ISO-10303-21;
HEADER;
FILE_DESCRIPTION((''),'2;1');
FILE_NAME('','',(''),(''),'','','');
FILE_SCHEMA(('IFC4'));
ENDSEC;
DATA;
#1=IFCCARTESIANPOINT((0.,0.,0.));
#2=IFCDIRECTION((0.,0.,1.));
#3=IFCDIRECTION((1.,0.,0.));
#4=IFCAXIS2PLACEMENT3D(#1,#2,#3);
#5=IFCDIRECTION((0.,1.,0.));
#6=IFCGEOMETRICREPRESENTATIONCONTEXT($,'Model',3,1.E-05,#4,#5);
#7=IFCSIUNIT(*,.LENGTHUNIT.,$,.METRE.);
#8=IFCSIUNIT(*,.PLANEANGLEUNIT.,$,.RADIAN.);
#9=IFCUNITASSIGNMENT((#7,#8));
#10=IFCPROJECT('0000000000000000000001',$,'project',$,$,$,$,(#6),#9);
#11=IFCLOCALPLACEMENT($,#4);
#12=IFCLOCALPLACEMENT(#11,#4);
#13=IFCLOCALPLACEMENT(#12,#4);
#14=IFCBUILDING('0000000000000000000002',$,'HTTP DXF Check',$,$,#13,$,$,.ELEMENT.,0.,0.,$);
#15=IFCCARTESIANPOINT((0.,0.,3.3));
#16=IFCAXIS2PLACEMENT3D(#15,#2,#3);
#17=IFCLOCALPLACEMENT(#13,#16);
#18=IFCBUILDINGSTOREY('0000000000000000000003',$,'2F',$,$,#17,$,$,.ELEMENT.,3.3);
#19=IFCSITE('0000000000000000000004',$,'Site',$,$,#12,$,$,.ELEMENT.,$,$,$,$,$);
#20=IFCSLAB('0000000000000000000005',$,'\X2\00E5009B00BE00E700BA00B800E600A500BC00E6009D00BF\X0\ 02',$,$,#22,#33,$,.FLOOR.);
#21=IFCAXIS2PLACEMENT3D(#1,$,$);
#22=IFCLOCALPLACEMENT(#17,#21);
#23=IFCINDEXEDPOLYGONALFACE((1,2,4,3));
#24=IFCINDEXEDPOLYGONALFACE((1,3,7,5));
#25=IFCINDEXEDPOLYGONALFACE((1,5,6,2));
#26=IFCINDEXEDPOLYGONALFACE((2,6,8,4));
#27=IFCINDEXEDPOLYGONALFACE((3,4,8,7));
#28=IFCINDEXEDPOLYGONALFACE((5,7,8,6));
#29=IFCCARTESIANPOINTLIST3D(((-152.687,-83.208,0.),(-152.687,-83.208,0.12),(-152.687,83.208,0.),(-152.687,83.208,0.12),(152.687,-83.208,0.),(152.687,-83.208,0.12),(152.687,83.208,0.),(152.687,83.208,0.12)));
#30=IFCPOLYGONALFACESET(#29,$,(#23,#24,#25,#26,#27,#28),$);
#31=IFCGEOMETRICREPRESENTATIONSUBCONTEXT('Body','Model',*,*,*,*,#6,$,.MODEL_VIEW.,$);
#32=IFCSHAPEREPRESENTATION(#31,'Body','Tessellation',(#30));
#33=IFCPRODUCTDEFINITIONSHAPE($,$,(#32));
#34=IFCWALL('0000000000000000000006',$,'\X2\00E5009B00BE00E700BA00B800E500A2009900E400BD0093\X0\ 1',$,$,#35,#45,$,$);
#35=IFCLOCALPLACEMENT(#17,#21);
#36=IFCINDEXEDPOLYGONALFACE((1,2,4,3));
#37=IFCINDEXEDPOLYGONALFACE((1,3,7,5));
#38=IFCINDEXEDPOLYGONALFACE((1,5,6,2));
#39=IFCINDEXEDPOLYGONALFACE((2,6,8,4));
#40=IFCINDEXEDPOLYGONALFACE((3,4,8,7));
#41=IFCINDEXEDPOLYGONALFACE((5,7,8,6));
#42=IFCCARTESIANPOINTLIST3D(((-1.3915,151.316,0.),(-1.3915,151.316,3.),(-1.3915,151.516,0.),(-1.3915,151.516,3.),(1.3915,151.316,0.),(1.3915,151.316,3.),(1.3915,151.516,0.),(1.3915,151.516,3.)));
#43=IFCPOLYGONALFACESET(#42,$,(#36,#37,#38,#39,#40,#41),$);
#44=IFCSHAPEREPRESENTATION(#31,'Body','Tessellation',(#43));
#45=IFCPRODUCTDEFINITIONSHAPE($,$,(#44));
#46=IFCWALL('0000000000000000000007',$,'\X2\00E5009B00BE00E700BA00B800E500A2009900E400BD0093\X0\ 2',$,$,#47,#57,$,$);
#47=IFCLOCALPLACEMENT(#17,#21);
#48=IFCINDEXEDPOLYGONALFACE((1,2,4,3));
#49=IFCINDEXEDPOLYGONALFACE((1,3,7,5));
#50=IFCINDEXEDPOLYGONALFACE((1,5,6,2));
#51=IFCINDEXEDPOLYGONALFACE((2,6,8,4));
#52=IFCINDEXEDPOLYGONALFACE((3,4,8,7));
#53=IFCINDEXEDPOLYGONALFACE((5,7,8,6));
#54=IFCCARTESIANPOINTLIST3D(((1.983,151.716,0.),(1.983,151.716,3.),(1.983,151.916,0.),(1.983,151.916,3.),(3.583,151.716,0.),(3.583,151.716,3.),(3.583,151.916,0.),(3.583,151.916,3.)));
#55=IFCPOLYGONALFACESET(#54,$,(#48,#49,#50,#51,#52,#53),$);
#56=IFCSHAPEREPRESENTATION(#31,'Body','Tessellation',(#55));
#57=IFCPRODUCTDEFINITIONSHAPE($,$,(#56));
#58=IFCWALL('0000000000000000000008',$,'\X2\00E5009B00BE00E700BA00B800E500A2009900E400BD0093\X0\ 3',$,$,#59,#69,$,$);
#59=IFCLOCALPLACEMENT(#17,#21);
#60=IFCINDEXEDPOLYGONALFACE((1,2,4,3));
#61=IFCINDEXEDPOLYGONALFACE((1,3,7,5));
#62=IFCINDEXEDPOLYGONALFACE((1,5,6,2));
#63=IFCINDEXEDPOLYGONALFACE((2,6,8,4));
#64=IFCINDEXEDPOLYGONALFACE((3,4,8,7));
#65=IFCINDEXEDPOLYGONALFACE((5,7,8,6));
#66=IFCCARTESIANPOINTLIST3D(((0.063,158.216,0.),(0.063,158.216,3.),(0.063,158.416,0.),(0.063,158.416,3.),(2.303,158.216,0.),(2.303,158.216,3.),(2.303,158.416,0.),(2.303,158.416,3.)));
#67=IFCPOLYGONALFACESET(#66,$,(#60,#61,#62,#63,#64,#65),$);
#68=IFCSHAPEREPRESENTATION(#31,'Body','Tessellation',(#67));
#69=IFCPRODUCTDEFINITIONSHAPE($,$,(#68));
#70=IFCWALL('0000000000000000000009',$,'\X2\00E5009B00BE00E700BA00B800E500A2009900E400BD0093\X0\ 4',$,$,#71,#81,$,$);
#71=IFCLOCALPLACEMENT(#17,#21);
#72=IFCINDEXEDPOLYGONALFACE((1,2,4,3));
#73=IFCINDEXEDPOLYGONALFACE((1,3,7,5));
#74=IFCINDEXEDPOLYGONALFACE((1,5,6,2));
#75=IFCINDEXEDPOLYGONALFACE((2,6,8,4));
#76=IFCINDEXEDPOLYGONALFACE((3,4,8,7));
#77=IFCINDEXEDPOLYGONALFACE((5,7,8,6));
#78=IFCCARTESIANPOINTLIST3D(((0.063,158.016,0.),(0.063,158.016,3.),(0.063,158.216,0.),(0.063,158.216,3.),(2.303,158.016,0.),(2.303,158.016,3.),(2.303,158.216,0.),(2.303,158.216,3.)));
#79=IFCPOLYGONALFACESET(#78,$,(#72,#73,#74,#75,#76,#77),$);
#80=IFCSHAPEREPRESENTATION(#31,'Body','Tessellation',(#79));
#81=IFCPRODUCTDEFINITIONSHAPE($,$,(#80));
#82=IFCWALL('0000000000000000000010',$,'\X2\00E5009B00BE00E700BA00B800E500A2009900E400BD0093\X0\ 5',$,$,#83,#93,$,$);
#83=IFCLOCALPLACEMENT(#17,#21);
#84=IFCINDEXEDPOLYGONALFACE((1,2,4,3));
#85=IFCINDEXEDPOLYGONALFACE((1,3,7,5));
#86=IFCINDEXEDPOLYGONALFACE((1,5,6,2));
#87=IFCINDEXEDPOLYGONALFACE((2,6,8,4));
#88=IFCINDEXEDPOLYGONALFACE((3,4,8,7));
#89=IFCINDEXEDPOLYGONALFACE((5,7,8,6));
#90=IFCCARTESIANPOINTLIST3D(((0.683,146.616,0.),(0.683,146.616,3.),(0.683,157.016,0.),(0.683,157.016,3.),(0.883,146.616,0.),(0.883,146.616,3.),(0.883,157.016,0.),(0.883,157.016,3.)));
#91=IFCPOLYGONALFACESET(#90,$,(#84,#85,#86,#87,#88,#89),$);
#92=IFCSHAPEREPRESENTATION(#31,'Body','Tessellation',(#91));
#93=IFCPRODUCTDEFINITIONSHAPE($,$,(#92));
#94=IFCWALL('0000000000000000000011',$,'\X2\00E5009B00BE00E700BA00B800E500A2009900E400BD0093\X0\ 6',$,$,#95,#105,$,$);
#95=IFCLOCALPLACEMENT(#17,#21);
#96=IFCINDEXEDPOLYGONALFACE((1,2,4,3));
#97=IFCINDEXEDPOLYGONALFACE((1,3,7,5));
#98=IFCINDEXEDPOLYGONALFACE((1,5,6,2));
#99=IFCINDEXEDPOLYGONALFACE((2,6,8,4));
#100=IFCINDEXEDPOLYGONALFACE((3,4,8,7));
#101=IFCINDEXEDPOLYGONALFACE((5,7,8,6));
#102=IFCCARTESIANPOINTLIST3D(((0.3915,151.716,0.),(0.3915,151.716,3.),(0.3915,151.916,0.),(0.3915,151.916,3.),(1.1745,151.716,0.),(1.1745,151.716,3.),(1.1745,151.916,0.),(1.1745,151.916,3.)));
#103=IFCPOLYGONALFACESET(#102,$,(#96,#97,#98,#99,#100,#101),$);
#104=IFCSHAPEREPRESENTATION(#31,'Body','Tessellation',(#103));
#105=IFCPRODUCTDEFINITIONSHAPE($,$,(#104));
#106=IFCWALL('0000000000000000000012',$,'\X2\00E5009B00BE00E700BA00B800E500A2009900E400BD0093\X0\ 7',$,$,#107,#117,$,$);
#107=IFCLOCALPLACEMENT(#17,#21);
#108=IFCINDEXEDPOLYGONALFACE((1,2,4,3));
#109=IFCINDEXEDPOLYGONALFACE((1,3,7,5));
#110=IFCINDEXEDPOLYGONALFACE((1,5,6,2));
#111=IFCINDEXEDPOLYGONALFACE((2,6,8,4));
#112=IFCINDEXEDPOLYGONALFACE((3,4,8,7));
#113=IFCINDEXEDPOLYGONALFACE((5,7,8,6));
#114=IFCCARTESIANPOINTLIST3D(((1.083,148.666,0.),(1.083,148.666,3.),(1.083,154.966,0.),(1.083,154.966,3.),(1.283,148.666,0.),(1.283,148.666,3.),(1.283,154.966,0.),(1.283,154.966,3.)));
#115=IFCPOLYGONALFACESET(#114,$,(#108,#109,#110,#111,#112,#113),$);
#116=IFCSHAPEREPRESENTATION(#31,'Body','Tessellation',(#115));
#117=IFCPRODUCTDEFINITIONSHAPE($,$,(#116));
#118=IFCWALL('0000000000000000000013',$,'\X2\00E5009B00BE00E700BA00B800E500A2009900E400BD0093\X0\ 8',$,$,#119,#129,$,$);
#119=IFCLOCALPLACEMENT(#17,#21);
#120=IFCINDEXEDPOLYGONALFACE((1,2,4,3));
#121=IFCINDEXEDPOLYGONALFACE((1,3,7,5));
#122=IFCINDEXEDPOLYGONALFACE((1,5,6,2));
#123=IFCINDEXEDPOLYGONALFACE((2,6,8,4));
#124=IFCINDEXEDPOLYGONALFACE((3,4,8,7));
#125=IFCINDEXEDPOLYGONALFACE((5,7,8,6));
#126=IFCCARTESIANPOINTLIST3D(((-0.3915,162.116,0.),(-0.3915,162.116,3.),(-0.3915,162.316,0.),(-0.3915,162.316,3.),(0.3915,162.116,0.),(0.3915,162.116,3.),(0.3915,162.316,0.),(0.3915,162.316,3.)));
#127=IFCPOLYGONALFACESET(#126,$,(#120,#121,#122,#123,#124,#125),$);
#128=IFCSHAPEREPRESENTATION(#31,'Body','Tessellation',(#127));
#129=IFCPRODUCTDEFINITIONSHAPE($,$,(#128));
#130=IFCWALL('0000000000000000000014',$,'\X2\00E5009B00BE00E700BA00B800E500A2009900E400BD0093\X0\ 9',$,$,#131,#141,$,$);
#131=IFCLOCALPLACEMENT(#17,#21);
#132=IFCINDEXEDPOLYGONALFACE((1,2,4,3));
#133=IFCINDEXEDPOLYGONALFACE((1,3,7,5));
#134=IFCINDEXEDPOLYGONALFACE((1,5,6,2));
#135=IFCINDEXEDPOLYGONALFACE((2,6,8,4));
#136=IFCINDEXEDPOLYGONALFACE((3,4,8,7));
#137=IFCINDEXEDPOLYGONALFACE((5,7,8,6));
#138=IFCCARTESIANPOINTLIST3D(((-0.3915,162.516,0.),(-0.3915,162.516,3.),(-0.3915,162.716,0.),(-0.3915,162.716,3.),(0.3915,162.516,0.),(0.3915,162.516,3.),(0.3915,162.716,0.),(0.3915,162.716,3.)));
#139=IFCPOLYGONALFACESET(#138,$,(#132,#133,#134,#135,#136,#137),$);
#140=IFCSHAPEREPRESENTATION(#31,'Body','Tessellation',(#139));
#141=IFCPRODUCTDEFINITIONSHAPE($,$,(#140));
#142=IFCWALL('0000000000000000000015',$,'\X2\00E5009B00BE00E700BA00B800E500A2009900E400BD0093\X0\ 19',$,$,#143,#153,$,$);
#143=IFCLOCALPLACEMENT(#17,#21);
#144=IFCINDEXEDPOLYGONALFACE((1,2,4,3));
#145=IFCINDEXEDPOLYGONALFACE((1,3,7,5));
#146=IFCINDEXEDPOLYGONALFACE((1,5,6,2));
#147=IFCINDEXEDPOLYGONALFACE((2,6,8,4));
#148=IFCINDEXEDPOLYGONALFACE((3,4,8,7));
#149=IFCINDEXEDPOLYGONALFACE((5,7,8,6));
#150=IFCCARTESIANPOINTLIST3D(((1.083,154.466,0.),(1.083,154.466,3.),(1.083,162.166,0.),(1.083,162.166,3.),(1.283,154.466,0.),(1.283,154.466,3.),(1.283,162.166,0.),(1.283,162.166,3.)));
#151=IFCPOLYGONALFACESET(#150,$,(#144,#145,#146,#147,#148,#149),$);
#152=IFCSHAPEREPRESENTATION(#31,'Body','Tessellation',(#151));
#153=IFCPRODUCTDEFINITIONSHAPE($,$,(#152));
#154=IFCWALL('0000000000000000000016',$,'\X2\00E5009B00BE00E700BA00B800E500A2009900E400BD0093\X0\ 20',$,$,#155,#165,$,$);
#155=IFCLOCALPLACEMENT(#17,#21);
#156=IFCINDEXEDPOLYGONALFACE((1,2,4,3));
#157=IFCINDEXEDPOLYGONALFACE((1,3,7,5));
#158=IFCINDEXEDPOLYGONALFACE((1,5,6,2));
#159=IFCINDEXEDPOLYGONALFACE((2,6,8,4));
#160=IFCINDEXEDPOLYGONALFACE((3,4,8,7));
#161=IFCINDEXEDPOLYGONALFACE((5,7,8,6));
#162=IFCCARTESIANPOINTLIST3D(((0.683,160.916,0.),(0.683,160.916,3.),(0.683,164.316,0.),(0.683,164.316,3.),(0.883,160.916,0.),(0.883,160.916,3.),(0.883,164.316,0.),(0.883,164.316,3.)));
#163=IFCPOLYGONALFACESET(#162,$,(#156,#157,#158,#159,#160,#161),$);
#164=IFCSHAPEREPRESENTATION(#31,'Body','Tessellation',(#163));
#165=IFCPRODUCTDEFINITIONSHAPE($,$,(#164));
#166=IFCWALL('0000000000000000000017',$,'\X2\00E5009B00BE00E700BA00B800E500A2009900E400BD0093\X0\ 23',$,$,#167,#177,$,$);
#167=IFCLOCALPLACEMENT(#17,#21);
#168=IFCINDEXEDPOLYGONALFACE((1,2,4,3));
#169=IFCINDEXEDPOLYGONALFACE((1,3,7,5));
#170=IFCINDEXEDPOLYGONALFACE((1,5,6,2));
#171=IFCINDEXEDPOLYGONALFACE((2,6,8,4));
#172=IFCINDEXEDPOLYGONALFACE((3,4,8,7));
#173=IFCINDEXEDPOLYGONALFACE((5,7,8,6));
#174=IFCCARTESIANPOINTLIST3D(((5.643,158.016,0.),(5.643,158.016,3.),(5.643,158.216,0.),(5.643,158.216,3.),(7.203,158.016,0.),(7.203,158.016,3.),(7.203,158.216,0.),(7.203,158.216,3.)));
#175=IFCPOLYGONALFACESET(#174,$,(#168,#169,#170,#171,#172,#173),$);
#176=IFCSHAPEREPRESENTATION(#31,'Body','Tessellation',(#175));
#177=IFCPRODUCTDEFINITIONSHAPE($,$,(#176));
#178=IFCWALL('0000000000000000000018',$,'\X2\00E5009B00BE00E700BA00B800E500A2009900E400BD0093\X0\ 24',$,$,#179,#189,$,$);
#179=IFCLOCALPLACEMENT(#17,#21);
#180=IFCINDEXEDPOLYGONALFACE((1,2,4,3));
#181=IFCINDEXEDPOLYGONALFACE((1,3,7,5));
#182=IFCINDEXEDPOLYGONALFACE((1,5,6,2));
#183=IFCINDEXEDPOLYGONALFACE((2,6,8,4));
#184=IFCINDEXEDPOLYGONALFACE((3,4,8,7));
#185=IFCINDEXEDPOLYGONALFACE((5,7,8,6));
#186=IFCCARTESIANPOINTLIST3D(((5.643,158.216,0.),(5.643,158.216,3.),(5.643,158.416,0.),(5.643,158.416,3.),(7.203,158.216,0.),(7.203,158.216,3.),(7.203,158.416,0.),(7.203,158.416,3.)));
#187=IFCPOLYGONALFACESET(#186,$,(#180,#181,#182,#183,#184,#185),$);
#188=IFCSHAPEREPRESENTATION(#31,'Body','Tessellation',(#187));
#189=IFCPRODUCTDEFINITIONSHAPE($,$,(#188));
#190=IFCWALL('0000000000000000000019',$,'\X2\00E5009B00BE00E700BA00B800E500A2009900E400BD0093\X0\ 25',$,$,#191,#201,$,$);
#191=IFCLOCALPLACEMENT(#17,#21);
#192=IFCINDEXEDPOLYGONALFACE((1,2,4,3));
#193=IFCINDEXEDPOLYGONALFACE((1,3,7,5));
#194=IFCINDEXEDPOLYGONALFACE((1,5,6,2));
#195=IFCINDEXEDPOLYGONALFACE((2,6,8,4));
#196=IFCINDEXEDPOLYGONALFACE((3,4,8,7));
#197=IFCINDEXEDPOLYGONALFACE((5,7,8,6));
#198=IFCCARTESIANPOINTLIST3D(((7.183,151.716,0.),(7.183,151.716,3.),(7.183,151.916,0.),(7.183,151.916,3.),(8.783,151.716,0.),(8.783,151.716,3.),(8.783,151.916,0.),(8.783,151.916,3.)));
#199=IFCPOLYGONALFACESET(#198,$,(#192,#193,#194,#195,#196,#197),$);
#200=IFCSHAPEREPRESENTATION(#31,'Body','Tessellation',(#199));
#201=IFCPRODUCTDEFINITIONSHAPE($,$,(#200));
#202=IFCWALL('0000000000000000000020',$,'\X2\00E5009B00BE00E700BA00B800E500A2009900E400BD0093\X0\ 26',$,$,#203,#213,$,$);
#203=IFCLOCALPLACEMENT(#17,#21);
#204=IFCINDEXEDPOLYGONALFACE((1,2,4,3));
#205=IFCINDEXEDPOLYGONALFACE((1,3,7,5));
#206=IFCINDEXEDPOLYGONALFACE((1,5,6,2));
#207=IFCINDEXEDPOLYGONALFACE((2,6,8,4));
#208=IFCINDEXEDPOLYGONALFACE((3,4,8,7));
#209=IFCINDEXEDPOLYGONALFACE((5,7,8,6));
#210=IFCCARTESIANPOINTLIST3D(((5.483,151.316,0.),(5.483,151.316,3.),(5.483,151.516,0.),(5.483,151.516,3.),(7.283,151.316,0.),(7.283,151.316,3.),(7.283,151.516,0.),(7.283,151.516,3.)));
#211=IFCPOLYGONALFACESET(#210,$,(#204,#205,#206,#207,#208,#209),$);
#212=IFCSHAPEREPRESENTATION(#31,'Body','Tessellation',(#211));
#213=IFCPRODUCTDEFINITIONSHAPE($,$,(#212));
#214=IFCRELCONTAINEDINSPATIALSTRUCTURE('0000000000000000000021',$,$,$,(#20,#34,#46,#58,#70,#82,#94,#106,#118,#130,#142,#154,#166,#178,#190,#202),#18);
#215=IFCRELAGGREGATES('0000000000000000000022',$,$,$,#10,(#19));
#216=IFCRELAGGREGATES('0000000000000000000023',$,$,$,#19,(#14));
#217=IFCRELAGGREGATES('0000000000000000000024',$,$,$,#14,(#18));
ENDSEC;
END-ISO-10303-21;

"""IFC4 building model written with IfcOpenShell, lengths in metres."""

from ifc_helpers import new_model, si_unit, direction, frame, frame_2d, origin_with_axes, place, context, subcontext, project, spatial, rectangle, extrude, element, save


model = new_model("IFC4")

# Units and contexts
model_context = context("Model", 3, precision=1e-05, world=origin_with_axes(), true_north=direction((0.0, 1.0, 0.0)))
body_context = subcontext(model_context, "Body", "Model", "MODEL_VIEW")
ifc_project = project(units=[si_unit("LENGTHUNIT", "METRE"), si_unit("PLANEANGLEUNIT", "RADIAN")], contexts=[model_context])

# Site, building, storey
placement = place(None, origin_with_axes())
site_placement = place(placement, origin_with_axes())
site = spatial("IfcSite", under=ifc_project, at=site_placement, Name="Site", CompositionType="ELEMENT")
building_placement = place(site_placement, origin_with_axes())
building = spatial("IfcBuilding", under=site, at=building_placement, Name="HTTP DXF Check", CompositionType="ELEMENT", ElevationOfRefHeight=0.0, ElevationOfTerrain=0.0)
storey_placement = place(building_placement, frame((0.0, 0.0, 3.3), z_axis=(0.0, 0.0, 1.0), x_axis=(1.0, 0.0, 0.0)))
storey = spatial("IfcBuildingStorey", under=building, at=storey_placement, Name="2F", CompositionType="ELEMENT", Elevation=3.3)

# Slab
slab_placement = place(storey_placement, origin_with_axes())
element("IfcSlab", 1, at=slab_placement, inside=storey, Name="å\u009b¾çº¸æ¥¼æ\u009d¿ 02", PredefinedType="FLOOR", context=body_context, shape_type="SweptSolid", body=[
    extrude(rectangle(XDim=305.374, YDim=166.416, at=frame_2d((0.0, 0.0), x_axis=(1.0, 0.0, 0.0))), frame((0.0, 0.0, 0.0), z_axis=(0.0, 0.0, 1.0)), (0.0, 0.0, 1.0), 0.12),
])

# Walls
wall_1_placement = place(storey_placement, frame((0.0, 151.416, 0.0), z_axis=(0.0, 0.0, 1.0), x_axis=(1.0, 0.0, 0.0)))
element("IfcWall", 2, at=wall_1_placement, inside=storey, Name="å\u009b¾çº¸å¢\u0099ä½\u0093 1", context=body_context, shape_type="SweptSolid", body=[
    extrude(rectangle(XDim=2.783, YDim=0.2, at=frame_2d((0.0, 0.0), x_axis=(1.0, 0.0, 0.0))), frame((0.0, 0.0, 0.0), z_axis=(0.0, 0.0, 1.0)), (0.0, 0.0, 1.0), 3.0),
])
wall_2_placement = place(storey_placement, frame((2.783, 151.816, 0.0), z_axis=(0.0, 0.0, 1.0), x_axis=(-1.0, 0.0, 0.0)))
element("IfcWall", 3, at=wall_2_placement, inside=storey, Name="å\u009b¾çº¸å¢\u0099ä½\u0093 2", context=body_context, shape_type="SweptSolid", body=[
    extrude(rectangle(XDim=1.6, YDim=0.2, at=frame_2d((0.0, 0.0), x_axis=(1.0, 0.0, 0.0))), frame((0.0, 0.0, 0.0), z_axis=(0.0, 0.0, 1.0)), (0.0, 0.0, 1.0), 3.0),
])
for number, where, z_axis, x_axis, name in (
    (4, (1.183, 158.316, 0.0), (0.0, 0.0, 1.0), (1.0, 0.0, 0.0), "å\u009b¾çº¸å¢\u0099ä½\u0093 3"),
    (5, (1.183, 158.116, 0.0), (0.0, 0.0, 1.0), (1.0, 0.0, 0.0), "å\u009b¾çº¸å¢\u0099ä½\u0093 4"),
):
    element("IfcWall", number, at=place(storey_placement, frame(where, z_axis=z_axis, x_axis=x_axis)), inside=storey, Name=name, context=body_context, shape_type="SweptSolid", body=[
        extrude(rectangle(XDim=2.24, YDim=0.2, at=frame_2d((0.0, 0.0), x_axis=(1.0, 0.0, 0.0))), frame((0.0, 0.0, 0.0), z_axis=(0.0, 0.0, 1.0)), (0.0, 0.0, 1.0), 3.0),
    ])
wall_3_placement = place(storey_placement, frame((0.783, 151.816, 0.0), z_axis=(0.0, 0.0, 1.0), x_axis=(0.0, 1.0, 0.0)))
element("IfcWall", 6, at=wall_3_placement, inside=storey, Name="å\u009b¾çº¸å¢\u0099ä½\u0093 5", context=body_context, shape_type="SweptSolid", body=[
    extrude(rectangle(XDim=10.4, YDim=0.2, at=frame_2d((0.0, 0.0), x_axis=(1.0, 0.0, 0.0))), frame((0.0, 0.0, 0.0), z_axis=(0.0, 0.0, 1.0)), (0.0, 0.0, 1.0), 3.0),
])
wall_4_placement = place(storey_placement, frame((0.783, 151.816, 0.0), z_axis=(0.0, 0.0, 1.0), x_axis=(-1.0, 0.0, 0.0)))
element("IfcWall", 7, at=wall_4_placement, inside=storey, Name="å\u009b¾çº¸å¢\u0099ä½\u0093 6", context=body_context, shape_type="SweptSolid", body=[
    extrude(rectangle(XDim=0.783, YDim=0.2, at=frame_2d((0.0, 0.0), x_axis=(1.0, 0.0, 0.0))), frame((0.0, 0.0, 0.0), z_axis=(0.0, 0.0, 1.0)), (0.0, 0.0, 1.0), 3.0),
])
wall_5_placement = place(storey_placement, frame((1.183, 151.816, 0.0), z_axis=(0.0, 0.0, 1.0), x_axis=(0.0, 1.0, 0.0)))
element("IfcWall", 8, at=wall_5_placement, inside=storey, Name="å\u009b¾çº¸å¢\u0099ä½\u0093 7", context=body_context, shape_type="SweptSolid", body=[
    extrude(rectangle(XDim=6.3, YDim=0.2, at=frame_2d((0.0, 0.0), x_axis=(1.0, 0.0, 0.0))), frame((0.0, 0.0, 0.0), z_axis=(0.0, 0.0, 1.0)), (0.0, 0.0, 1.0), 3.0),
])
for number, where, z_axis, x_axis, name in (
    (9, (0.0, 162.216, 0.0), (0.0, 0.0, 1.0), (1.0, 0.0, 0.0), "å\u009b¾çº¸å¢\u0099ä½\u0093 8"),
    (10, (0.0, 162.616, 0.0), (0.0, 0.0, 1.0), (1.0, 0.0, 0.0), "å\u009b¾çº¸å¢\u0099ä½\u0093 9"),
):
    element("IfcWall", number, at=place(storey_placement, frame(where, z_axis=z_axis, x_axis=x_axis)), inside=storey, Name=name, context=body_context, shape_type="SweptSolid", body=[
        extrude(rectangle(XDim=0.783, YDim=0.2, at=frame_2d((0.0, 0.0), x_axis=(1.0, 0.0, 0.0))), frame((0.0, 0.0, 0.0), z_axis=(0.0, 0.0, 1.0)), (0.0, 0.0, 1.0), 3.0),
    ])
wall_6_placement = place(storey_placement, frame((1.183, 158.316, 0.0), z_axis=(0.0, 0.0, 1.0), x_axis=(0.0, 1.0, 0.0)))
element("IfcWall", 11, at=wall_6_placement, inside=storey, Name="å\u009b¾çº¸å¢\u0099ä½\u0093 19", context=body_context, shape_type="SweptSolid", body=[
    extrude(rectangle(XDim=7.7, YDim=0.2, at=frame_2d((0.0, 0.0), x_axis=(1.0, 0.0, 0.0))), frame((0.0, 0.0, 0.0), z_axis=(0.0, 0.0, 1.0)), (0.0, 0.0, 1.0), 3.0),
])
wall_7_placement = place(storey_placement, frame((0.783, 162.616, 0.0), z_axis=(0.0, 0.0, 1.0), x_axis=(0.0, 1.0, 0.0)))
element("IfcWall", 12, at=wall_7_placement, inside=storey, Name="å\u009b¾çº¸å¢\u0099ä½\u0093 20", context=body_context, shape_type="SweptSolid", body=[
    extrude(rectangle(XDim=3.4, YDim=0.2, at=frame_2d((0.0, 0.0), x_axis=(1.0, 0.0, 0.0))), frame((0.0, 0.0, 0.0), z_axis=(0.0, 0.0, 1.0)), (0.0, 0.0, 1.0), 3.0),
])
for number, where, z_axis, x_axis, name in (
    (13, (6.423, 158.116, 0.0), (0.0, 0.0, 1.0), (1.0, 0.0, 0.0), "å\u009b¾çº¸å¢\u0099ä½\u0093 23"),
    (14, (6.423, 158.316, 0.0), (0.0, 0.0, 1.0), (1.0, 0.0, 0.0), "å\u009b¾çº¸å¢\u0099ä½\u0093 24"),
):
    element("IfcWall", number, at=place(storey_placement, frame(where, z_axis=z_axis, x_axis=x_axis)), inside=storey, Name=name, context=body_context, shape_type="SweptSolid", body=[
        extrude(rectangle(XDim=1.56, YDim=0.2, at=frame_2d((0.0, 0.0), x_axis=(1.0, 0.0, 0.0))), frame((0.0, 0.0, 0.0), z_axis=(0.0, 0.0, 1.0)), (0.0, 0.0, 1.0), 3.0),
    ])
wall_8_placement = place(storey_placement, frame((7.983, 151.816, 0.0), z_axis=(0.0, 0.0, 1.0), x_axis=(-1.0, 0.0, 0.0)))
element("IfcWall", 15, at=wall_8_placement, inside=storey, Name="å\u009b¾çº¸å¢\u0099ä½\u0093 25", context=body_context, shape_type="SweptSolid", body=[
    extrude(rectangle(XDim=1.6, YDim=0.2, at=frame_2d((0.0, 0.0), x_axis=(1.0, 0.0, 0.0))), frame((0.0, 0.0, 0.0), z_axis=(0.0, 0.0, 1.0)), (0.0, 0.0, 1.0), 3.0),
])
wall_9_placement = place(storey_placement, frame((6.383, 151.416, 0.0), z_axis=(0.0, 0.0, 1.0), x_axis=(1.0, 0.0, 0.0)))
element("IfcWall", 16, at=wall_9_placement, inside=storey, Name="å\u009b¾çº¸å¢\u0099ä½\u0093 26", context=body_context, shape_type="SweptSolid", body=[
    extrude(rectangle(XDim=1.8, YDim=0.2, at=frame_2d((0.0, 0.0), x_axis=(1.0, 0.0, 0.0))), frame((0.0, 0.0, 0.0), z_axis=(0.0, 0.0, 1.0)), (0.0, 0.0, 1.0), 3.0),
])

save(model, "model.ifc")
